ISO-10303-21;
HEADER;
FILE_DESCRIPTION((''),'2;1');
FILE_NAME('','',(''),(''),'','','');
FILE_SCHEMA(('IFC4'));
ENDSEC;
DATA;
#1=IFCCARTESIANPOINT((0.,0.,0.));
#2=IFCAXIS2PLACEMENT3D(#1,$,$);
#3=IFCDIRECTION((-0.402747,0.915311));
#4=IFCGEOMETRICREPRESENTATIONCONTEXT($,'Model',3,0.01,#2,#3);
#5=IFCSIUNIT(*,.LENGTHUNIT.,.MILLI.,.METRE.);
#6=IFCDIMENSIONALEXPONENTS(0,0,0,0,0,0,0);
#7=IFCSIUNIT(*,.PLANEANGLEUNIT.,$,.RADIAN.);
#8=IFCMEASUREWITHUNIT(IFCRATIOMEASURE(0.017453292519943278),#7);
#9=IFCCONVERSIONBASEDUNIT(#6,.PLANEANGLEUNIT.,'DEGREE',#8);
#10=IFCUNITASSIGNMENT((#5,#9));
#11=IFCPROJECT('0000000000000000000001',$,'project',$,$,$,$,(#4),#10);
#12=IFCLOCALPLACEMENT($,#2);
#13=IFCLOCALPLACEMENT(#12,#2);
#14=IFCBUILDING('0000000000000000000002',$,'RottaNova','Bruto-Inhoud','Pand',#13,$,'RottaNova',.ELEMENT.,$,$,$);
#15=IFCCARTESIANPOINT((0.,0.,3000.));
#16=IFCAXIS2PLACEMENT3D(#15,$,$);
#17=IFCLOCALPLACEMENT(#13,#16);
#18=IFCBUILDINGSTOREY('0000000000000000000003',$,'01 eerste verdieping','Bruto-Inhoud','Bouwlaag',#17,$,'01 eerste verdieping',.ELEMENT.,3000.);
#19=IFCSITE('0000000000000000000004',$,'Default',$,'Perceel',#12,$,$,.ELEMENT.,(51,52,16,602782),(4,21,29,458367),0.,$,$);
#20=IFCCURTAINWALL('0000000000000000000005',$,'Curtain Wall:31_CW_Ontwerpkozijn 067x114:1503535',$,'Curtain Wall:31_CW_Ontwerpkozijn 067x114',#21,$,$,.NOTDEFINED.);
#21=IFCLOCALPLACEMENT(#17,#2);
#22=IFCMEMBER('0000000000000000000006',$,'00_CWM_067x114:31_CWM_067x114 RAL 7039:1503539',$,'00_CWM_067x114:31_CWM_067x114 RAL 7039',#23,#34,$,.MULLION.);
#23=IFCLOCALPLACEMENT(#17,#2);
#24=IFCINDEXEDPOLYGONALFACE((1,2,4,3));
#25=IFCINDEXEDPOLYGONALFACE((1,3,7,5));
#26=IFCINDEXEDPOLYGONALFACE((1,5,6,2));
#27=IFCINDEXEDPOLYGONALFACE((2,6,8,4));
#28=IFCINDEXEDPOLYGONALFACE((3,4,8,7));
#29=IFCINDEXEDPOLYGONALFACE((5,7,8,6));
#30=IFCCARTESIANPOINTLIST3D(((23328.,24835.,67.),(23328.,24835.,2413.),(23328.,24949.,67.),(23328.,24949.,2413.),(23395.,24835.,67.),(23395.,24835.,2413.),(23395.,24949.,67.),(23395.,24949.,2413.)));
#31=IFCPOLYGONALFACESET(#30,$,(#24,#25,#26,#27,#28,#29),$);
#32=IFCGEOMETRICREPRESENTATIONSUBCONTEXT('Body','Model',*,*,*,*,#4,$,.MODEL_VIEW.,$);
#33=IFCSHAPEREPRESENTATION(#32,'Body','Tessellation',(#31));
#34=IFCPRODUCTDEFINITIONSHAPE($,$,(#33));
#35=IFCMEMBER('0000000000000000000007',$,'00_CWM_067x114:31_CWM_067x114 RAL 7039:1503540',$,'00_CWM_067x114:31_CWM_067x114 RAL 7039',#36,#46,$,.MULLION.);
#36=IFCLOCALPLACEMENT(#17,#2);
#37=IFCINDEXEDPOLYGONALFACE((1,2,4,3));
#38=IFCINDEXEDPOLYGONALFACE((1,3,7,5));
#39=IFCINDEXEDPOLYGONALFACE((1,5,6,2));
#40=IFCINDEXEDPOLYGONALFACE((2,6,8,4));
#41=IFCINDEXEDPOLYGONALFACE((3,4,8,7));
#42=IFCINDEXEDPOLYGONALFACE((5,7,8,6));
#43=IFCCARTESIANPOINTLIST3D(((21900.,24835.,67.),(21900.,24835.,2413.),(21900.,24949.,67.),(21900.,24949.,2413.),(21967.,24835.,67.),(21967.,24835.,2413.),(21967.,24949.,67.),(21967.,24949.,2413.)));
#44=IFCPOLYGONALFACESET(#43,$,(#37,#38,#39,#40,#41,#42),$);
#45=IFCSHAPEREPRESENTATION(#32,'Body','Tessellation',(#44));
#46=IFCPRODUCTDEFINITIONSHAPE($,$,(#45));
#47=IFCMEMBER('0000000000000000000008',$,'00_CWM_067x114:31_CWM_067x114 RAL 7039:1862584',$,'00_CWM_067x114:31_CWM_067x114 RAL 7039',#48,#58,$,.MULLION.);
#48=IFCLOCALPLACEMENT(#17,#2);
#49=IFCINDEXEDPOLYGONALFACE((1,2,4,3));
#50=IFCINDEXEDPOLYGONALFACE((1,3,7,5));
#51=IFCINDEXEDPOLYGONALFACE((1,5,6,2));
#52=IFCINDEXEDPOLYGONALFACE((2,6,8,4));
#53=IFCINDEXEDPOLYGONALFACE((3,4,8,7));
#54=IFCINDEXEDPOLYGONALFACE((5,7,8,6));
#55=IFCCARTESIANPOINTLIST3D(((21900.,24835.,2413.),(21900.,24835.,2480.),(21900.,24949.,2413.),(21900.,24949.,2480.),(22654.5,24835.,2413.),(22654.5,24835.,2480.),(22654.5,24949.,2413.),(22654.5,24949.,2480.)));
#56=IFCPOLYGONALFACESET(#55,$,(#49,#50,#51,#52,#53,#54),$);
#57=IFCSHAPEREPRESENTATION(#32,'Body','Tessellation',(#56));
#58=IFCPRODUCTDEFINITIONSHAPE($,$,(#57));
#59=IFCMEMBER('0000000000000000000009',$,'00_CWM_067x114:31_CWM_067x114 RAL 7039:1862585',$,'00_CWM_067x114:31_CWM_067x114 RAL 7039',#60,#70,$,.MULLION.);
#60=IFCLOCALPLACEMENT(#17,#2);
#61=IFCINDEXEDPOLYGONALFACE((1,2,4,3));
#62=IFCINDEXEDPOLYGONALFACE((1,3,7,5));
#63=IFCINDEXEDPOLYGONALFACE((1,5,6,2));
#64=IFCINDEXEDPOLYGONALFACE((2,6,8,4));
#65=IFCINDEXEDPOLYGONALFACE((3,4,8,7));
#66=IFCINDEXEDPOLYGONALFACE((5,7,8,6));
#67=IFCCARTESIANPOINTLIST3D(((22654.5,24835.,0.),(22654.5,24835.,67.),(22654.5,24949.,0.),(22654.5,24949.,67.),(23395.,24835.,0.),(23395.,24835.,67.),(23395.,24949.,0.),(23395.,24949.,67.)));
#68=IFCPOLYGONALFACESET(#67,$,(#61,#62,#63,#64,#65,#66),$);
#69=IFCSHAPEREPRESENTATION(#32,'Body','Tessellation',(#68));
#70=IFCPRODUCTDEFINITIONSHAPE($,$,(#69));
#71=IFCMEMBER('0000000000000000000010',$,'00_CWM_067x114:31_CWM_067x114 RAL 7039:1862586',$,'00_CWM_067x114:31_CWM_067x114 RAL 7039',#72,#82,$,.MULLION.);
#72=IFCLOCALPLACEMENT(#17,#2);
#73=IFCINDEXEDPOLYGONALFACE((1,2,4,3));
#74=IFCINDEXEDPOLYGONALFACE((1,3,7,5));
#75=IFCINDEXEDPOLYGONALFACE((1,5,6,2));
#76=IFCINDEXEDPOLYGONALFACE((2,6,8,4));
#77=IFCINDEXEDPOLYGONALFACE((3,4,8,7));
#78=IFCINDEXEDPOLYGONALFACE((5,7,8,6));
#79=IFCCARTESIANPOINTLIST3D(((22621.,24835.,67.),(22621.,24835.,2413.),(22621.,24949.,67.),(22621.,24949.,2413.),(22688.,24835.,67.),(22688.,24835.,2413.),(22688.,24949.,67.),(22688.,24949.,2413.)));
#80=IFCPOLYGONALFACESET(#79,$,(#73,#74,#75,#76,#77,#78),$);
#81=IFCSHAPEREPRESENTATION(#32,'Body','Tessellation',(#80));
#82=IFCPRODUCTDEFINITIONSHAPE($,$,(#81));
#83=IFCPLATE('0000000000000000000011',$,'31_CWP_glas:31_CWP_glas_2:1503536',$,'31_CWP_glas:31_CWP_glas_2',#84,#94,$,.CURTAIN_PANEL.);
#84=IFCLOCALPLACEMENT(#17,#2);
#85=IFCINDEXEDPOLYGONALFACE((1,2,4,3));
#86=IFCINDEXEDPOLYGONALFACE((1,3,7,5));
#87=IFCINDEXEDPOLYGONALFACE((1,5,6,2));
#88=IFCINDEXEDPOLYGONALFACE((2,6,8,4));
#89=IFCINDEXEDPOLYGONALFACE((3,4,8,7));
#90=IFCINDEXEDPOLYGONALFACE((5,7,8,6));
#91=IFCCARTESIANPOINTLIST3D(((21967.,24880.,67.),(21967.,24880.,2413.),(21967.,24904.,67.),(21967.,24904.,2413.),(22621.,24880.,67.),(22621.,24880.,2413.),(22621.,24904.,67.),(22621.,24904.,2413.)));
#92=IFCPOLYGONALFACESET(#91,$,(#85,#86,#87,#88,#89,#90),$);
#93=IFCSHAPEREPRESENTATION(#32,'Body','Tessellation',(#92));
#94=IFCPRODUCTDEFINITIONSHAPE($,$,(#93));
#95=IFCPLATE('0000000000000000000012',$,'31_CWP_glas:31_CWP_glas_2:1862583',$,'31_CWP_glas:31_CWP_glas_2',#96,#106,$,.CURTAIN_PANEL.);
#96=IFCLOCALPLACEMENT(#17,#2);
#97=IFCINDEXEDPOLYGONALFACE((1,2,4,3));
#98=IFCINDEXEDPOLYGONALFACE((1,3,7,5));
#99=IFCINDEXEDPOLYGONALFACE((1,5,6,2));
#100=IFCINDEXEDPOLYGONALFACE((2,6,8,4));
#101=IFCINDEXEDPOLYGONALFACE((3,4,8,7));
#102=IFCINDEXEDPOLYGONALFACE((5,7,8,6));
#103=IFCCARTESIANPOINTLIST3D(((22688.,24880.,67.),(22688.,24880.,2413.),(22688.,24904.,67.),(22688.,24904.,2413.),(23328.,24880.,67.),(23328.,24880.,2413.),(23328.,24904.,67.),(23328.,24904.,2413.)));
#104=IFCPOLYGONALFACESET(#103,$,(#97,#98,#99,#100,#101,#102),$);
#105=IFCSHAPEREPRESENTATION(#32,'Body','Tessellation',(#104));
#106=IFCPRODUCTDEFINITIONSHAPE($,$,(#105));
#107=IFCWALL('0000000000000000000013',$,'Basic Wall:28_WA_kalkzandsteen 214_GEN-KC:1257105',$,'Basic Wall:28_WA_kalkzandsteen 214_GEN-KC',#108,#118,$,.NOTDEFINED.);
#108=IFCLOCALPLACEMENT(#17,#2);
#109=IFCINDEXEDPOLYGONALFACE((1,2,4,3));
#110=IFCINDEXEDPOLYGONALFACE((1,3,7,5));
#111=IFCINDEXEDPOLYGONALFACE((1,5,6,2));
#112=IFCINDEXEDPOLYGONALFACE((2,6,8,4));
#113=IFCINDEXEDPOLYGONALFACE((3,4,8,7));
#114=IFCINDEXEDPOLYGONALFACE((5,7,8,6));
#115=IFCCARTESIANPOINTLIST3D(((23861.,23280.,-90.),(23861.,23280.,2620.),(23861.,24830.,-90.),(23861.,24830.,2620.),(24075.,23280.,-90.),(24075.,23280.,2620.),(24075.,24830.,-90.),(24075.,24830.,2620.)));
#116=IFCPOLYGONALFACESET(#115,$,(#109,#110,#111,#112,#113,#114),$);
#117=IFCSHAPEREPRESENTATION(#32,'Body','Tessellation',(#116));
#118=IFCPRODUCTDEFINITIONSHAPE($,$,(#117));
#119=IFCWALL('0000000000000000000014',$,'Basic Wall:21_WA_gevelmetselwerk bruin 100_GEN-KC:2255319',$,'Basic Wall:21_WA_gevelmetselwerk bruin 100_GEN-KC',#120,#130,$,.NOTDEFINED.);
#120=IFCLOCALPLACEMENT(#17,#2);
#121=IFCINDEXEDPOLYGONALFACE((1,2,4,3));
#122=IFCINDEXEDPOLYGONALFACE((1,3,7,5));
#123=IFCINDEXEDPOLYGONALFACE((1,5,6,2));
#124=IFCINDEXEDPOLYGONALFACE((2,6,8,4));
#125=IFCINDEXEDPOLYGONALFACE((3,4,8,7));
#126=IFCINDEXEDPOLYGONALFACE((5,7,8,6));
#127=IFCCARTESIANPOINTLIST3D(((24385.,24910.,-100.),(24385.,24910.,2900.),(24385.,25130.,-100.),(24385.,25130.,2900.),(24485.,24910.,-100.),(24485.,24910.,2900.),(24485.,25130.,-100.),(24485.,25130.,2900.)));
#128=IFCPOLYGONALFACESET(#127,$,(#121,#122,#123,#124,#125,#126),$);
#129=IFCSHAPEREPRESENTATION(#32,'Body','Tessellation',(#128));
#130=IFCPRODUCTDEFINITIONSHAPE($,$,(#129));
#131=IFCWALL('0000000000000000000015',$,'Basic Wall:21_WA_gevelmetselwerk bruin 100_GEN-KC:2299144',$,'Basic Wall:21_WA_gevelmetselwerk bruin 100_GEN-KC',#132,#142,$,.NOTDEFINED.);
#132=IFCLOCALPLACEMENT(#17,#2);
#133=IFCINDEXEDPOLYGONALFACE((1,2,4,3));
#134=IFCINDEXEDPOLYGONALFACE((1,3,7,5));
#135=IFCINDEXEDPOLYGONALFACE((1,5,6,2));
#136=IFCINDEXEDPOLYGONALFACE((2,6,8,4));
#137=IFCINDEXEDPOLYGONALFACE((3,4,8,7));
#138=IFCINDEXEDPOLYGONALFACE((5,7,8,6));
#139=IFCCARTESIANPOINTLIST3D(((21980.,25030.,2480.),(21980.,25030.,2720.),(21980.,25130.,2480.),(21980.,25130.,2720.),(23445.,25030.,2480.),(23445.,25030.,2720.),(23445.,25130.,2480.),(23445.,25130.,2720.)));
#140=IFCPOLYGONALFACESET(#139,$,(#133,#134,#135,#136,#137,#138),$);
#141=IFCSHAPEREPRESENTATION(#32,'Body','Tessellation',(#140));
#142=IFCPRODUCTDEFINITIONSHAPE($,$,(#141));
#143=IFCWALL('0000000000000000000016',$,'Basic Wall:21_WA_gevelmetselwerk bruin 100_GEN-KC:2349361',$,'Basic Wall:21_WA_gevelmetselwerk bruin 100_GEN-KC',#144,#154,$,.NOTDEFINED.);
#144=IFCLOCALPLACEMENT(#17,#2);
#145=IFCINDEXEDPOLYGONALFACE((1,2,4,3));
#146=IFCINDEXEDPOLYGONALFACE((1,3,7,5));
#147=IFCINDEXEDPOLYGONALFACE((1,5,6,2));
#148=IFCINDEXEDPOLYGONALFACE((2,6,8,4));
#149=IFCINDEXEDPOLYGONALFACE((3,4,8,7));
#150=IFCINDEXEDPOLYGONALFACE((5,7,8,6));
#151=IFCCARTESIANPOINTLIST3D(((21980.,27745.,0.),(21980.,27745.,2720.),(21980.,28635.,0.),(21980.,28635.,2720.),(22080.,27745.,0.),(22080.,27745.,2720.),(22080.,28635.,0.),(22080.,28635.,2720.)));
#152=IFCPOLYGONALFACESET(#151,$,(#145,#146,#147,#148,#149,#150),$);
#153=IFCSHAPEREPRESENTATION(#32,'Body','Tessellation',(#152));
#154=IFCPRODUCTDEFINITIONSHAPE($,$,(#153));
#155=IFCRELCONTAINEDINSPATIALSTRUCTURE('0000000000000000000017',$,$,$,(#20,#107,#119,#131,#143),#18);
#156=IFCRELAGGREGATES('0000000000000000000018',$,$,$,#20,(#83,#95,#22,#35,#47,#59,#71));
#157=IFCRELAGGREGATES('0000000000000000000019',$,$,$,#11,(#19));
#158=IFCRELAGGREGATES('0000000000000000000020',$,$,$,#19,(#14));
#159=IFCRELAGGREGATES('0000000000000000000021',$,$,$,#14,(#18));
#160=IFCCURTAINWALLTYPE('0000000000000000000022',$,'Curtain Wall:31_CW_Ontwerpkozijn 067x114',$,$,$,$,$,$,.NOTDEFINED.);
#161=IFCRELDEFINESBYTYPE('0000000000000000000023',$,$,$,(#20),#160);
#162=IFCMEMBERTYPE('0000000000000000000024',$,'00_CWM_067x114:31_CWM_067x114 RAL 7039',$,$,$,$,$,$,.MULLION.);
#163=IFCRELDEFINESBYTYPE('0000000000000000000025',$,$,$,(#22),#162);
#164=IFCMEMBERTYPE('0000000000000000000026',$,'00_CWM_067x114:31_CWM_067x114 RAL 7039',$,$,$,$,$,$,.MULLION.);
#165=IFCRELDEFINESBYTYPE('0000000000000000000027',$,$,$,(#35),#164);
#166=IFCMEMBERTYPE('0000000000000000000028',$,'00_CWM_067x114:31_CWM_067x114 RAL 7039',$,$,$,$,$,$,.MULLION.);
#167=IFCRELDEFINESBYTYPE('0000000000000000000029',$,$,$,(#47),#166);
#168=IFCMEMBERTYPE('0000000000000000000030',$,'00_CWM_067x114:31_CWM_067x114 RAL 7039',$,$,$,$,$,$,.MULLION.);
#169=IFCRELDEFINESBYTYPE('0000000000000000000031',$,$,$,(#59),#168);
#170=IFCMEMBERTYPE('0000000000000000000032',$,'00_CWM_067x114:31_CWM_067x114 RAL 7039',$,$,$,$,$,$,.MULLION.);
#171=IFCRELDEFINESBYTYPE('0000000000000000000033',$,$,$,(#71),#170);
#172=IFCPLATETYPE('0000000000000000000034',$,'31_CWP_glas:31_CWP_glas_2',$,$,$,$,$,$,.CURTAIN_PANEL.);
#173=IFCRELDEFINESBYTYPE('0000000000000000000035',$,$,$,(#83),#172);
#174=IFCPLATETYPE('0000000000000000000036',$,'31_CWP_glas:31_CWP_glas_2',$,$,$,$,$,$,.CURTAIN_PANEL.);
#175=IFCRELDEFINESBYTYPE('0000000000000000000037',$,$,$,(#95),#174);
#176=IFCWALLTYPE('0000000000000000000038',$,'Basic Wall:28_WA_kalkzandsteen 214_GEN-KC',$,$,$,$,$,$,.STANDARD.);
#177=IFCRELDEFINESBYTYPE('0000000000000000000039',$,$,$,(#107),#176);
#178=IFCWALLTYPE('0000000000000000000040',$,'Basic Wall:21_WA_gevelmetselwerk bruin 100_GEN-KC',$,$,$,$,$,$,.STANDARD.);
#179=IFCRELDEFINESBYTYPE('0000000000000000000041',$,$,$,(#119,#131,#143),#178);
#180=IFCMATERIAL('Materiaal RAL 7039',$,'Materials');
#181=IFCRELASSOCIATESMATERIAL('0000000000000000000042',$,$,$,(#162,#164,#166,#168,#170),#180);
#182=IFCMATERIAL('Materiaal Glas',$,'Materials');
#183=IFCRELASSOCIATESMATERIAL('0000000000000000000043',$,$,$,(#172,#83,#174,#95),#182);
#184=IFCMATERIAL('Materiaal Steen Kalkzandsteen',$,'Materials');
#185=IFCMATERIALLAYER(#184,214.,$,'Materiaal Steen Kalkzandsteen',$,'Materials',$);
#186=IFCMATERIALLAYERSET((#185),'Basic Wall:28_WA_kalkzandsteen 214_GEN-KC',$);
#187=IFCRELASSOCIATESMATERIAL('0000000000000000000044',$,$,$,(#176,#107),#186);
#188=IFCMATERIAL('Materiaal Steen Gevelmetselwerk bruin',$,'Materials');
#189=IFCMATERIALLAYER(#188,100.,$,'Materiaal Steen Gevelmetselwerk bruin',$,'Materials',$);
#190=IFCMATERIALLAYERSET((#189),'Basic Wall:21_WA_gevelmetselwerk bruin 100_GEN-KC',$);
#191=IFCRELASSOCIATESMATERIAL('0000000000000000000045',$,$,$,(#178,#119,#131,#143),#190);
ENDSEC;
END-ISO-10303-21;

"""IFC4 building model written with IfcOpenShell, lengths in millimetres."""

from ifc_helpers import new_model, entity, si_unit, converted_unit, direction, frame, frame_2d, origin, origin_2d_with_axis, place, context, subcontext, project, spatial, rectangle, extrude, source, transform, mapped, material, layer, layer_set, material_profile, profile_set, type_object, type_shapes, element, aggregate, save


model = new_model("IFC4")

# Units and contexts
model_context = context("Model", 3, precision=0.01, world=origin(), true_north=direction((-0.402747, 0.915311)))
body_context = subcontext(model_context, "Body", "Model", "MODEL_VIEW")
ifc_project = project(units=[si_unit("LENGTHUNIT", "METRE", prefix="MILLI"), converted_unit("PLANEANGLEUNIT", "DEGREE", entity("IfcRatioMeasure", 0.017453292519943278), si_unit("PLANEANGLEUNIT", "RADIAN"), dimensions=[0, 0, 0, 0, 0, 0, 0])], contexts=[model_context])

# Site, building, storey
site_placement = place(None, origin())
site = spatial("IfcSite", under=ifc_project, at=site_placement, Name="Default", ObjectType="Perceel", CompositionType="ELEMENT", RefLatitude=(51, 52, 16, 602782), RefLongitude=(4, 21, 29, 458367), RefElevation=0.0)
building_placement = place(site_placement, origin())
building = spatial("IfcBuilding", under=site, at=building_placement, Name="RottaNova", Description="Bruto-Inhoud", ObjectType="Pand", LongName="RottaNova", CompositionType="ELEMENT")
storey_placement = place(building_placement, frame((0.0, 0.0, 3000.0)))
storey = spatial("IfcBuildingStorey", under=building, at=storey_placement, Name="01 eerste verdieping", Description="Bruto-Inhoud", ObjectType="Bouwlaag", LongName="01 eerste verdieping", CompositionType="ELEMENT", Elevation=3000.0)

# Shared definitions
curtain_wall_type = type_object("IfcCurtainWallType", Name="Curtain Wall:31_CW_Ontwerpkozijn 067x114", PredefinedType="NOTDEFINED")
ifc_material_1 = material(Name="Materiaal RAL 7039", Category="Materials")

# Curtain wall, members, plates
curtain_wall_1_placement = place(storey_placement, frame((0.0, 0.0, -3000.0)))
curtain_wall_1 = element("IfcCurtainWall", 1, at=curtain_wall_1_placement, inside=storey, type_object=curtain_wall_type, Name="Curtain Wall:31_CW_Ontwerpkozijn 067x114:1503535", ObjectType="Curtain Wall:31_CW_Ontwerpkozijn 067x114", PredefinedType="NOTDEFINED")
ifc_material_profile_1 = material_profile(ifc_material_1, rectangle(XDim=114.0, YDim=67.0, at=origin_2d_with_axis()), Name="31_CWM_067x114 RAL 7039")
ifc_profile_set_1 = profile_set([ifc_material_profile_1], Name="31_CWM_067x114 RAL 7039")
member_type_1 = type_object("IfcMemberType", Name="00_CWM_067x114:31_CWM_067x114 RAL 7039", PredefinedType="MULLION", material=ifc_profile_set_1)
shared_shape_1 = source(origin(), body_context, "Body", "SweptSolid", [
    extrude(rectangle(XDim=114.0, YDim=67.0, at=frame_2d((0.0, 0.0), x_axis=(1.0, 0.0))), frame((-33.5, -57.0, -2346.0), z_axis=(0.0, 0.0, 1.0), x_axis=(0.0, -1.0, 0.0)), (0.0, 0.0, 1.0), 2346.0),
])
type_shapes(member_type_1, [shared_shape_1])
member_1_placement = place(curtain_wall_1_placement, frame((23395.0, 24835.0, 3067.0), z_axis=(0.0, 0.0, -1.0), x_axis=(1.0, 0.0, 0.0)))
member_1 = element("IfcMember", 2, at=member_1_placement, type_object=member_type_1, Name="00_CWM_067x114:31_CWM_067x114 RAL 7039:1503539", ObjectType="00_CWM_067x114:31_CWM_067x114 RAL 7039", PredefinedType="MULLION", context=body_context, shape_type="MappedRepresentation", body=[
    mapped(shared_shape_1, transform((0.0, 0.0, 0.0), scale=1.0)),
])
member_type_2 = type_object("IfcMemberType", Name="00_CWM_067x114:31_CWM_067x114 RAL 7039", PredefinedType="MULLION", material=ifc_profile_set_1)
shared_shape_2 = source(origin(), body_context, "Body", "SweptSolid", [
    extrude(rectangle(XDim=114.0, YDim=67.0, at=frame_2d((0.0, 0.0), x_axis=(1.0, 0.0))), frame((-33.5, -57.0, -2346.0), z_axis=(0.0, 0.0, 1.0), x_axis=(0.0, -1.0, 0.0)), (0.0, 0.0, 1.0), 2346.0),
])
type_shapes(member_type_2, [shared_shape_2])
member_2_placement = place(curtain_wall_1_placement, frame((21900.0, 24835.0, 5413.0), z_axis=(0.0, 0.0, 1.0), x_axis=(-1.0, 0.0, 0.0)))
member_2 = element("IfcMember", 3, at=member_2_placement, type_object=member_type_2, Name="00_CWM_067x114:31_CWM_067x114 RAL 7039:1503540", ObjectType="00_CWM_067x114:31_CWM_067x114 RAL 7039", PredefinedType="MULLION", context=body_context, shape_type="MappedRepresentation", body=[
    mapped(shared_shape_2, transform((0.0, 0.0, 0.0), scale=1.0)),
])
member_type_3 = type_object("IfcMemberType", Name="00_CWM_067x114:31_CWM_067x114 RAL 7039", PredefinedType="MULLION", material=ifc_profile_set_1)
shared_shape_3 = source(origin(), body_context, "Body", "SweptSolid", [
    extrude(rectangle(XDim=114.0, YDim=67.0, at=frame_2d((0.0, 0.0), x_axis=(1.0, 0.0))), frame((-33.5, -57.0, -754.5), z_axis=(0.0, 0.0, 1.0), x_axis=(0.0, -1.0, 0.0)), (0.0, 0.0, 1.0), 754.5),
])
type_shapes(member_type_3, [shared_shape_3])
member_3_placement = place(curtain_wall_1_placement, frame((22654.5, 24835.0, 5480.0), z_axis=(1.0, 0.0, 0.0), x_axis=(0.0, 0.0, 1.0)))
member_3 = element("IfcMember", 4, at=member_3_placement, type_object=member_type_3, Name="00_CWM_067x114:31_CWM_067x114 RAL 7039:1862584", ObjectType="00_CWM_067x114:31_CWM_067x114 RAL 7039", PredefinedType="MULLION", context=body_context, shape_type="MappedRepresentation", body=[
    mapped(shared_shape_3, transform((0.0, 0.0, 0.0), scale=1.0)),
])
member_type_4 = type_object("IfcMemberType", Name="00_CWM_067x114:31_CWM_067x114 RAL 7039", PredefinedType="MULLION", material=ifc_profile_set_1)
shared_shape_4 = source(origin(), body_context, "Body", "SweptSolid", [
    extrude(rectangle(XDim=114.0, YDim=67.0, at=frame_2d((0.0, 0.0), x_axis=(1.0, 0.0))), frame((-33.5, -57.0, -740.5), z_axis=(0.0, 0.0, 1.0), x_axis=(0.0, -1.0, 0.0)), (0.0, 0.0, 1.0), 740.5),
])
type_shapes(member_type_4, [shared_shape_4])
member_4_placement = place(curtain_wall_1_placement, frame((22654.5, 24835.0, 3000.0), z_axis=(-1.0, 0.0, 0.0), x_axis=(0.0, 0.0, -1.0)))
member_4 = element("IfcMember", 5, at=member_4_placement, type_object=member_type_4, Name="00_CWM_067x114:31_CWM_067x114 RAL 7039:1862585", ObjectType="00_CWM_067x114:31_CWM_067x114 RAL 7039", PredefinedType="MULLION", context=body_context, shape_type="MappedRepresentation", body=[
    mapped(shared_shape_4, transform((0.0, 0.0, 0.0), scale=1.0)),
])
member_type_5 = type_object("IfcMemberType", Name="00_CWM_067x114:31_CWM_067x114 RAL 7039", PredefinedType="MULLION", material=ifc_profile_set_1)
shared_shape_5 = source(origin(), body_context, "Body", "SweptSolid", [
    extrude(rectangle(XDim=114.0, YDim=67.0, at=frame_2d((0.0, 0.0), x_axis=(1.0, 0.0))), frame((0.0, -57.0, -2346.0), z_axis=(0.0, 0.0, 1.0), x_axis=(0.0, -1.0, 0.0)), (0.0, 0.0, 1.0), 2346.0),
])
type_shapes(member_type_5, [shared_shape_5])
member_5_placement = place(curtain_wall_1_placement, frame((22654.5, 24835.0, 3067.0), z_axis=(0.0, 0.0, -1.0), x_axis=(1.0, 0.0, 0.0)))
member_5 = element("IfcMember", 6, at=member_5_placement, type_object=member_type_5, Name="00_CWM_067x114:31_CWM_067x114 RAL 7039:1862586", ObjectType="00_CWM_067x114:31_CWM_067x114 RAL 7039", PredefinedType="MULLION", context=body_context, shape_type="MappedRepresentation", body=[
    mapped(shared_shape_5, transform((0.0, 0.0, 0.0), scale=1.0)),
])
ifc_material_2 = material(Name="Materiaal Glas", Category="Materials")
plate_type_1 = type_object("IfcPlateType", Name="31_CWP_glas:31_CWP_glas_2", PredefinedType="CURTAIN_PANEL", material=ifc_material_2)
shared_shape_6 = source(origin(), body_context, "Body", "SweptSolid", [
    extrude(rectangle(XDim=24.0, YDim=654.0, at=frame_2d((0.0, 0.0), x_axis=(1.0, 0.0))), frame((327.0, 12.0, 0.0), z_axis=(0.0, 0.0, 1.0), x_axis=(0.0, 1.0, 0.0)), (0.0, 0.0, 1.0), 2346.0),
])
type_shapes(plate_type_1, [shared_shape_6])
plate_1_placement = place(curtain_wall_1_placement, frame((21967.0, 24880.0, 3067.0)))
plate_1 = element("IfcPlate", 7, at=plate_1_placement, type_object=plate_type_1, material=ifc_material_2, Name="31_CWP_glas:31_CWP_glas_2:1503536", ObjectType="31_CWP_glas:31_CWP_glas_2", PredefinedType="CURTAIN_PANEL", context=body_context, shape_type="MappedRepresentation", body=[
    mapped(shared_shape_6, transform((0.0, 0.0, 0.0), scale=1.0)),
])
plate_type_2 = type_object("IfcPlateType", Name="31_CWP_glas:31_CWP_glas_2", PredefinedType="CURTAIN_PANEL", material=ifc_material_2)
shared_shape_7 = source(origin(), body_context, "Body", "SweptSolid", [
    extrude(rectangle(XDim=24.0, YDim=640.0, at=frame_2d((0.0, 0.0), x_axis=(1.0, 0.0))), frame((320.0, 12.0, 0.0), z_axis=(0.0, 0.0, 1.0), x_axis=(0.0, 1.0, 0.0)), (0.0, 0.0, 1.0), 2346.0),
])
type_shapes(plate_type_2, [shared_shape_7])
plate_2_placement = place(curtain_wall_1_placement, frame((22688.0, 24880.0, 3067.0)))
plate_2 = element("IfcPlate", 8, at=plate_2_placement, type_object=plate_type_2, material=ifc_material_2, Name="31_CWP_glas:31_CWP_glas_2:1862583", ObjectType="31_CWP_glas:31_CWP_glas_2", PredefinedType="CURTAIN_PANEL", context=body_context, shape_type="MappedRepresentation", body=[
    mapped(shared_shape_7, transform((0.0, 0.0, 0.0), scale=1.0)),
])
aggregate(curtain_wall_1, [plate_1, plate_2, member_1, member_2, member_3, member_4, member_5])

# Walls
ifc_material_3 = material(Name="Materiaal Steen Kalkzandsteen", Category="Materials")
ifc_layer_1 = layer(ifc_material_3, 214.0, Name="Materiaal Steen Kalkzandsteen", Category="Materials")
ifc_layer_set_1 = layer_set([ifc_layer_1], Name="Basic Wall:28_WA_kalkzandsteen 214_GEN-KC")
wall_type_1 = type_object("IfcWallType", Name="Basic Wall:28_WA_kalkzandsteen 214_GEN-KC", PredefinedType="STANDARD", material=ifc_layer_set_1)
wall_1_placement = place(storey_placement, frame((23968.0, 24830.0, -90.0), z_axis=(0.0, 0.0, 1.0), x_axis=(0.0, -1.0, 0.0)))
element("IfcWall", 9, at=wall_1_placement, inside=storey, type_object=wall_type_1, material=ifc_layer_set_1, Name="Basic Wall:28_WA_kalkzandsteen 214_GEN-KC:1257105", ObjectType="Basic Wall:28_WA_kalkzandsteen 214_GEN-KC", PredefinedType="NOTDEFINED", context=body_context, shape_type="SweptSolid", body=[
    extrude(rectangle(XDim=1550.0, YDim=214.0, at=frame_2d((775.0, 0.0), x_axis=(-1.0, 0.0))), origin(), (0.0, 0.0, 1.0), 2710.0),
])
ifc_material_4 = material(Name="Materiaal Steen Gevelmetselwerk bruin", Category="Materials")
ifc_layer_2 = layer(ifc_material_4, 100.0, Name="Materiaal Steen Gevelmetselwerk bruin", Category="Materials")
ifc_layer_set_2 = layer_set([ifc_layer_2], Name="Basic Wall:21_WA_gevelmetselwerk bruin 100_GEN-KC")
wall_type_2 = type_object("IfcWallType", Name="Basic Wall:21_WA_gevelmetselwerk bruin 100_GEN-KC", PredefinedType="STANDARD", material=ifc_layer_set_2)
wall_2_placement = place(storey_placement, frame((24435.0, 25130.0, -100.0), z_axis=(0.0, 0.0, 1.0), x_axis=(0.0, -1.0, 0.0)))
element("IfcWall", 10, at=wall_2_placement, inside=storey, type_object=wall_type_2, material=ifc_layer_set_2, Name="Basic Wall:21_WA_gevelmetselwerk bruin 100_GEN-KC:2255319", ObjectType="Basic Wall:21_WA_gevelmetselwerk bruin 100_GEN-KC", PredefinedType="NOTDEFINED", context=body_context, shape_type="SweptSolid", body=[
    extrude(rectangle(XDim=220.0, YDim=100.0, at=frame_2d((110.0, 0.0), x_axis=(-1.0, 0.0))), origin(), (0.0, 0.0, 1.0), 3000.0),
])
wall_3_placement = place(storey_placement, frame((23445.0, 25080.0, 2480.0), z_axis=(0.0, 0.0, 1.0), x_axis=(-1.0, 0.0, 0.0)))
element("IfcWall", 11, at=wall_3_placement, inside=storey, type_object=wall_type_2, material=ifc_layer_set_2, Name="Basic Wall:21_WA_gevelmetselwerk bruin 100_GEN-KC:2299144", ObjectType="Basic Wall:21_WA_gevelmetselwerk bruin 100_GEN-KC", PredefinedType="NOTDEFINED", context=body_context, shape_type="SweptSolid", body=[
    extrude(rectangle(XDim=1465.0, YDim=100.0, at=frame_2d((732.5, 0.0), x_axis=(-1.0, 0.0))), origin(), (0.0, 0.0, 1.0), 240.0),
])
wall_4_placement = place(storey_placement, frame((22030.0, 27745.0, 0.0), z_axis=(0.0, 0.0, 1.0), x_axis=(0.0, 1.0, 0.0)))
element("IfcWall", 12, at=wall_4_placement, inside=storey, type_object=wall_type_2, material=ifc_layer_set_2, Name="Basic Wall:21_WA_gevelmetselwerk bruin 100_GEN-KC:2349361", ObjectType="Basic Wall:21_WA_gevelmetselwerk bruin 100_GEN-KC", PredefinedType="NOTDEFINED", context=body_context, shape_type="SweptSolid", body=[
    extrude(rectangle(XDim=890.0, YDim=100.0, at=frame_2d((445.0, 0.0), x_axis=(-1.0, 0.0))), origin(), (0.0, 0.0, 1.0), 2720.0),
])

save(model, "model.ifc")
